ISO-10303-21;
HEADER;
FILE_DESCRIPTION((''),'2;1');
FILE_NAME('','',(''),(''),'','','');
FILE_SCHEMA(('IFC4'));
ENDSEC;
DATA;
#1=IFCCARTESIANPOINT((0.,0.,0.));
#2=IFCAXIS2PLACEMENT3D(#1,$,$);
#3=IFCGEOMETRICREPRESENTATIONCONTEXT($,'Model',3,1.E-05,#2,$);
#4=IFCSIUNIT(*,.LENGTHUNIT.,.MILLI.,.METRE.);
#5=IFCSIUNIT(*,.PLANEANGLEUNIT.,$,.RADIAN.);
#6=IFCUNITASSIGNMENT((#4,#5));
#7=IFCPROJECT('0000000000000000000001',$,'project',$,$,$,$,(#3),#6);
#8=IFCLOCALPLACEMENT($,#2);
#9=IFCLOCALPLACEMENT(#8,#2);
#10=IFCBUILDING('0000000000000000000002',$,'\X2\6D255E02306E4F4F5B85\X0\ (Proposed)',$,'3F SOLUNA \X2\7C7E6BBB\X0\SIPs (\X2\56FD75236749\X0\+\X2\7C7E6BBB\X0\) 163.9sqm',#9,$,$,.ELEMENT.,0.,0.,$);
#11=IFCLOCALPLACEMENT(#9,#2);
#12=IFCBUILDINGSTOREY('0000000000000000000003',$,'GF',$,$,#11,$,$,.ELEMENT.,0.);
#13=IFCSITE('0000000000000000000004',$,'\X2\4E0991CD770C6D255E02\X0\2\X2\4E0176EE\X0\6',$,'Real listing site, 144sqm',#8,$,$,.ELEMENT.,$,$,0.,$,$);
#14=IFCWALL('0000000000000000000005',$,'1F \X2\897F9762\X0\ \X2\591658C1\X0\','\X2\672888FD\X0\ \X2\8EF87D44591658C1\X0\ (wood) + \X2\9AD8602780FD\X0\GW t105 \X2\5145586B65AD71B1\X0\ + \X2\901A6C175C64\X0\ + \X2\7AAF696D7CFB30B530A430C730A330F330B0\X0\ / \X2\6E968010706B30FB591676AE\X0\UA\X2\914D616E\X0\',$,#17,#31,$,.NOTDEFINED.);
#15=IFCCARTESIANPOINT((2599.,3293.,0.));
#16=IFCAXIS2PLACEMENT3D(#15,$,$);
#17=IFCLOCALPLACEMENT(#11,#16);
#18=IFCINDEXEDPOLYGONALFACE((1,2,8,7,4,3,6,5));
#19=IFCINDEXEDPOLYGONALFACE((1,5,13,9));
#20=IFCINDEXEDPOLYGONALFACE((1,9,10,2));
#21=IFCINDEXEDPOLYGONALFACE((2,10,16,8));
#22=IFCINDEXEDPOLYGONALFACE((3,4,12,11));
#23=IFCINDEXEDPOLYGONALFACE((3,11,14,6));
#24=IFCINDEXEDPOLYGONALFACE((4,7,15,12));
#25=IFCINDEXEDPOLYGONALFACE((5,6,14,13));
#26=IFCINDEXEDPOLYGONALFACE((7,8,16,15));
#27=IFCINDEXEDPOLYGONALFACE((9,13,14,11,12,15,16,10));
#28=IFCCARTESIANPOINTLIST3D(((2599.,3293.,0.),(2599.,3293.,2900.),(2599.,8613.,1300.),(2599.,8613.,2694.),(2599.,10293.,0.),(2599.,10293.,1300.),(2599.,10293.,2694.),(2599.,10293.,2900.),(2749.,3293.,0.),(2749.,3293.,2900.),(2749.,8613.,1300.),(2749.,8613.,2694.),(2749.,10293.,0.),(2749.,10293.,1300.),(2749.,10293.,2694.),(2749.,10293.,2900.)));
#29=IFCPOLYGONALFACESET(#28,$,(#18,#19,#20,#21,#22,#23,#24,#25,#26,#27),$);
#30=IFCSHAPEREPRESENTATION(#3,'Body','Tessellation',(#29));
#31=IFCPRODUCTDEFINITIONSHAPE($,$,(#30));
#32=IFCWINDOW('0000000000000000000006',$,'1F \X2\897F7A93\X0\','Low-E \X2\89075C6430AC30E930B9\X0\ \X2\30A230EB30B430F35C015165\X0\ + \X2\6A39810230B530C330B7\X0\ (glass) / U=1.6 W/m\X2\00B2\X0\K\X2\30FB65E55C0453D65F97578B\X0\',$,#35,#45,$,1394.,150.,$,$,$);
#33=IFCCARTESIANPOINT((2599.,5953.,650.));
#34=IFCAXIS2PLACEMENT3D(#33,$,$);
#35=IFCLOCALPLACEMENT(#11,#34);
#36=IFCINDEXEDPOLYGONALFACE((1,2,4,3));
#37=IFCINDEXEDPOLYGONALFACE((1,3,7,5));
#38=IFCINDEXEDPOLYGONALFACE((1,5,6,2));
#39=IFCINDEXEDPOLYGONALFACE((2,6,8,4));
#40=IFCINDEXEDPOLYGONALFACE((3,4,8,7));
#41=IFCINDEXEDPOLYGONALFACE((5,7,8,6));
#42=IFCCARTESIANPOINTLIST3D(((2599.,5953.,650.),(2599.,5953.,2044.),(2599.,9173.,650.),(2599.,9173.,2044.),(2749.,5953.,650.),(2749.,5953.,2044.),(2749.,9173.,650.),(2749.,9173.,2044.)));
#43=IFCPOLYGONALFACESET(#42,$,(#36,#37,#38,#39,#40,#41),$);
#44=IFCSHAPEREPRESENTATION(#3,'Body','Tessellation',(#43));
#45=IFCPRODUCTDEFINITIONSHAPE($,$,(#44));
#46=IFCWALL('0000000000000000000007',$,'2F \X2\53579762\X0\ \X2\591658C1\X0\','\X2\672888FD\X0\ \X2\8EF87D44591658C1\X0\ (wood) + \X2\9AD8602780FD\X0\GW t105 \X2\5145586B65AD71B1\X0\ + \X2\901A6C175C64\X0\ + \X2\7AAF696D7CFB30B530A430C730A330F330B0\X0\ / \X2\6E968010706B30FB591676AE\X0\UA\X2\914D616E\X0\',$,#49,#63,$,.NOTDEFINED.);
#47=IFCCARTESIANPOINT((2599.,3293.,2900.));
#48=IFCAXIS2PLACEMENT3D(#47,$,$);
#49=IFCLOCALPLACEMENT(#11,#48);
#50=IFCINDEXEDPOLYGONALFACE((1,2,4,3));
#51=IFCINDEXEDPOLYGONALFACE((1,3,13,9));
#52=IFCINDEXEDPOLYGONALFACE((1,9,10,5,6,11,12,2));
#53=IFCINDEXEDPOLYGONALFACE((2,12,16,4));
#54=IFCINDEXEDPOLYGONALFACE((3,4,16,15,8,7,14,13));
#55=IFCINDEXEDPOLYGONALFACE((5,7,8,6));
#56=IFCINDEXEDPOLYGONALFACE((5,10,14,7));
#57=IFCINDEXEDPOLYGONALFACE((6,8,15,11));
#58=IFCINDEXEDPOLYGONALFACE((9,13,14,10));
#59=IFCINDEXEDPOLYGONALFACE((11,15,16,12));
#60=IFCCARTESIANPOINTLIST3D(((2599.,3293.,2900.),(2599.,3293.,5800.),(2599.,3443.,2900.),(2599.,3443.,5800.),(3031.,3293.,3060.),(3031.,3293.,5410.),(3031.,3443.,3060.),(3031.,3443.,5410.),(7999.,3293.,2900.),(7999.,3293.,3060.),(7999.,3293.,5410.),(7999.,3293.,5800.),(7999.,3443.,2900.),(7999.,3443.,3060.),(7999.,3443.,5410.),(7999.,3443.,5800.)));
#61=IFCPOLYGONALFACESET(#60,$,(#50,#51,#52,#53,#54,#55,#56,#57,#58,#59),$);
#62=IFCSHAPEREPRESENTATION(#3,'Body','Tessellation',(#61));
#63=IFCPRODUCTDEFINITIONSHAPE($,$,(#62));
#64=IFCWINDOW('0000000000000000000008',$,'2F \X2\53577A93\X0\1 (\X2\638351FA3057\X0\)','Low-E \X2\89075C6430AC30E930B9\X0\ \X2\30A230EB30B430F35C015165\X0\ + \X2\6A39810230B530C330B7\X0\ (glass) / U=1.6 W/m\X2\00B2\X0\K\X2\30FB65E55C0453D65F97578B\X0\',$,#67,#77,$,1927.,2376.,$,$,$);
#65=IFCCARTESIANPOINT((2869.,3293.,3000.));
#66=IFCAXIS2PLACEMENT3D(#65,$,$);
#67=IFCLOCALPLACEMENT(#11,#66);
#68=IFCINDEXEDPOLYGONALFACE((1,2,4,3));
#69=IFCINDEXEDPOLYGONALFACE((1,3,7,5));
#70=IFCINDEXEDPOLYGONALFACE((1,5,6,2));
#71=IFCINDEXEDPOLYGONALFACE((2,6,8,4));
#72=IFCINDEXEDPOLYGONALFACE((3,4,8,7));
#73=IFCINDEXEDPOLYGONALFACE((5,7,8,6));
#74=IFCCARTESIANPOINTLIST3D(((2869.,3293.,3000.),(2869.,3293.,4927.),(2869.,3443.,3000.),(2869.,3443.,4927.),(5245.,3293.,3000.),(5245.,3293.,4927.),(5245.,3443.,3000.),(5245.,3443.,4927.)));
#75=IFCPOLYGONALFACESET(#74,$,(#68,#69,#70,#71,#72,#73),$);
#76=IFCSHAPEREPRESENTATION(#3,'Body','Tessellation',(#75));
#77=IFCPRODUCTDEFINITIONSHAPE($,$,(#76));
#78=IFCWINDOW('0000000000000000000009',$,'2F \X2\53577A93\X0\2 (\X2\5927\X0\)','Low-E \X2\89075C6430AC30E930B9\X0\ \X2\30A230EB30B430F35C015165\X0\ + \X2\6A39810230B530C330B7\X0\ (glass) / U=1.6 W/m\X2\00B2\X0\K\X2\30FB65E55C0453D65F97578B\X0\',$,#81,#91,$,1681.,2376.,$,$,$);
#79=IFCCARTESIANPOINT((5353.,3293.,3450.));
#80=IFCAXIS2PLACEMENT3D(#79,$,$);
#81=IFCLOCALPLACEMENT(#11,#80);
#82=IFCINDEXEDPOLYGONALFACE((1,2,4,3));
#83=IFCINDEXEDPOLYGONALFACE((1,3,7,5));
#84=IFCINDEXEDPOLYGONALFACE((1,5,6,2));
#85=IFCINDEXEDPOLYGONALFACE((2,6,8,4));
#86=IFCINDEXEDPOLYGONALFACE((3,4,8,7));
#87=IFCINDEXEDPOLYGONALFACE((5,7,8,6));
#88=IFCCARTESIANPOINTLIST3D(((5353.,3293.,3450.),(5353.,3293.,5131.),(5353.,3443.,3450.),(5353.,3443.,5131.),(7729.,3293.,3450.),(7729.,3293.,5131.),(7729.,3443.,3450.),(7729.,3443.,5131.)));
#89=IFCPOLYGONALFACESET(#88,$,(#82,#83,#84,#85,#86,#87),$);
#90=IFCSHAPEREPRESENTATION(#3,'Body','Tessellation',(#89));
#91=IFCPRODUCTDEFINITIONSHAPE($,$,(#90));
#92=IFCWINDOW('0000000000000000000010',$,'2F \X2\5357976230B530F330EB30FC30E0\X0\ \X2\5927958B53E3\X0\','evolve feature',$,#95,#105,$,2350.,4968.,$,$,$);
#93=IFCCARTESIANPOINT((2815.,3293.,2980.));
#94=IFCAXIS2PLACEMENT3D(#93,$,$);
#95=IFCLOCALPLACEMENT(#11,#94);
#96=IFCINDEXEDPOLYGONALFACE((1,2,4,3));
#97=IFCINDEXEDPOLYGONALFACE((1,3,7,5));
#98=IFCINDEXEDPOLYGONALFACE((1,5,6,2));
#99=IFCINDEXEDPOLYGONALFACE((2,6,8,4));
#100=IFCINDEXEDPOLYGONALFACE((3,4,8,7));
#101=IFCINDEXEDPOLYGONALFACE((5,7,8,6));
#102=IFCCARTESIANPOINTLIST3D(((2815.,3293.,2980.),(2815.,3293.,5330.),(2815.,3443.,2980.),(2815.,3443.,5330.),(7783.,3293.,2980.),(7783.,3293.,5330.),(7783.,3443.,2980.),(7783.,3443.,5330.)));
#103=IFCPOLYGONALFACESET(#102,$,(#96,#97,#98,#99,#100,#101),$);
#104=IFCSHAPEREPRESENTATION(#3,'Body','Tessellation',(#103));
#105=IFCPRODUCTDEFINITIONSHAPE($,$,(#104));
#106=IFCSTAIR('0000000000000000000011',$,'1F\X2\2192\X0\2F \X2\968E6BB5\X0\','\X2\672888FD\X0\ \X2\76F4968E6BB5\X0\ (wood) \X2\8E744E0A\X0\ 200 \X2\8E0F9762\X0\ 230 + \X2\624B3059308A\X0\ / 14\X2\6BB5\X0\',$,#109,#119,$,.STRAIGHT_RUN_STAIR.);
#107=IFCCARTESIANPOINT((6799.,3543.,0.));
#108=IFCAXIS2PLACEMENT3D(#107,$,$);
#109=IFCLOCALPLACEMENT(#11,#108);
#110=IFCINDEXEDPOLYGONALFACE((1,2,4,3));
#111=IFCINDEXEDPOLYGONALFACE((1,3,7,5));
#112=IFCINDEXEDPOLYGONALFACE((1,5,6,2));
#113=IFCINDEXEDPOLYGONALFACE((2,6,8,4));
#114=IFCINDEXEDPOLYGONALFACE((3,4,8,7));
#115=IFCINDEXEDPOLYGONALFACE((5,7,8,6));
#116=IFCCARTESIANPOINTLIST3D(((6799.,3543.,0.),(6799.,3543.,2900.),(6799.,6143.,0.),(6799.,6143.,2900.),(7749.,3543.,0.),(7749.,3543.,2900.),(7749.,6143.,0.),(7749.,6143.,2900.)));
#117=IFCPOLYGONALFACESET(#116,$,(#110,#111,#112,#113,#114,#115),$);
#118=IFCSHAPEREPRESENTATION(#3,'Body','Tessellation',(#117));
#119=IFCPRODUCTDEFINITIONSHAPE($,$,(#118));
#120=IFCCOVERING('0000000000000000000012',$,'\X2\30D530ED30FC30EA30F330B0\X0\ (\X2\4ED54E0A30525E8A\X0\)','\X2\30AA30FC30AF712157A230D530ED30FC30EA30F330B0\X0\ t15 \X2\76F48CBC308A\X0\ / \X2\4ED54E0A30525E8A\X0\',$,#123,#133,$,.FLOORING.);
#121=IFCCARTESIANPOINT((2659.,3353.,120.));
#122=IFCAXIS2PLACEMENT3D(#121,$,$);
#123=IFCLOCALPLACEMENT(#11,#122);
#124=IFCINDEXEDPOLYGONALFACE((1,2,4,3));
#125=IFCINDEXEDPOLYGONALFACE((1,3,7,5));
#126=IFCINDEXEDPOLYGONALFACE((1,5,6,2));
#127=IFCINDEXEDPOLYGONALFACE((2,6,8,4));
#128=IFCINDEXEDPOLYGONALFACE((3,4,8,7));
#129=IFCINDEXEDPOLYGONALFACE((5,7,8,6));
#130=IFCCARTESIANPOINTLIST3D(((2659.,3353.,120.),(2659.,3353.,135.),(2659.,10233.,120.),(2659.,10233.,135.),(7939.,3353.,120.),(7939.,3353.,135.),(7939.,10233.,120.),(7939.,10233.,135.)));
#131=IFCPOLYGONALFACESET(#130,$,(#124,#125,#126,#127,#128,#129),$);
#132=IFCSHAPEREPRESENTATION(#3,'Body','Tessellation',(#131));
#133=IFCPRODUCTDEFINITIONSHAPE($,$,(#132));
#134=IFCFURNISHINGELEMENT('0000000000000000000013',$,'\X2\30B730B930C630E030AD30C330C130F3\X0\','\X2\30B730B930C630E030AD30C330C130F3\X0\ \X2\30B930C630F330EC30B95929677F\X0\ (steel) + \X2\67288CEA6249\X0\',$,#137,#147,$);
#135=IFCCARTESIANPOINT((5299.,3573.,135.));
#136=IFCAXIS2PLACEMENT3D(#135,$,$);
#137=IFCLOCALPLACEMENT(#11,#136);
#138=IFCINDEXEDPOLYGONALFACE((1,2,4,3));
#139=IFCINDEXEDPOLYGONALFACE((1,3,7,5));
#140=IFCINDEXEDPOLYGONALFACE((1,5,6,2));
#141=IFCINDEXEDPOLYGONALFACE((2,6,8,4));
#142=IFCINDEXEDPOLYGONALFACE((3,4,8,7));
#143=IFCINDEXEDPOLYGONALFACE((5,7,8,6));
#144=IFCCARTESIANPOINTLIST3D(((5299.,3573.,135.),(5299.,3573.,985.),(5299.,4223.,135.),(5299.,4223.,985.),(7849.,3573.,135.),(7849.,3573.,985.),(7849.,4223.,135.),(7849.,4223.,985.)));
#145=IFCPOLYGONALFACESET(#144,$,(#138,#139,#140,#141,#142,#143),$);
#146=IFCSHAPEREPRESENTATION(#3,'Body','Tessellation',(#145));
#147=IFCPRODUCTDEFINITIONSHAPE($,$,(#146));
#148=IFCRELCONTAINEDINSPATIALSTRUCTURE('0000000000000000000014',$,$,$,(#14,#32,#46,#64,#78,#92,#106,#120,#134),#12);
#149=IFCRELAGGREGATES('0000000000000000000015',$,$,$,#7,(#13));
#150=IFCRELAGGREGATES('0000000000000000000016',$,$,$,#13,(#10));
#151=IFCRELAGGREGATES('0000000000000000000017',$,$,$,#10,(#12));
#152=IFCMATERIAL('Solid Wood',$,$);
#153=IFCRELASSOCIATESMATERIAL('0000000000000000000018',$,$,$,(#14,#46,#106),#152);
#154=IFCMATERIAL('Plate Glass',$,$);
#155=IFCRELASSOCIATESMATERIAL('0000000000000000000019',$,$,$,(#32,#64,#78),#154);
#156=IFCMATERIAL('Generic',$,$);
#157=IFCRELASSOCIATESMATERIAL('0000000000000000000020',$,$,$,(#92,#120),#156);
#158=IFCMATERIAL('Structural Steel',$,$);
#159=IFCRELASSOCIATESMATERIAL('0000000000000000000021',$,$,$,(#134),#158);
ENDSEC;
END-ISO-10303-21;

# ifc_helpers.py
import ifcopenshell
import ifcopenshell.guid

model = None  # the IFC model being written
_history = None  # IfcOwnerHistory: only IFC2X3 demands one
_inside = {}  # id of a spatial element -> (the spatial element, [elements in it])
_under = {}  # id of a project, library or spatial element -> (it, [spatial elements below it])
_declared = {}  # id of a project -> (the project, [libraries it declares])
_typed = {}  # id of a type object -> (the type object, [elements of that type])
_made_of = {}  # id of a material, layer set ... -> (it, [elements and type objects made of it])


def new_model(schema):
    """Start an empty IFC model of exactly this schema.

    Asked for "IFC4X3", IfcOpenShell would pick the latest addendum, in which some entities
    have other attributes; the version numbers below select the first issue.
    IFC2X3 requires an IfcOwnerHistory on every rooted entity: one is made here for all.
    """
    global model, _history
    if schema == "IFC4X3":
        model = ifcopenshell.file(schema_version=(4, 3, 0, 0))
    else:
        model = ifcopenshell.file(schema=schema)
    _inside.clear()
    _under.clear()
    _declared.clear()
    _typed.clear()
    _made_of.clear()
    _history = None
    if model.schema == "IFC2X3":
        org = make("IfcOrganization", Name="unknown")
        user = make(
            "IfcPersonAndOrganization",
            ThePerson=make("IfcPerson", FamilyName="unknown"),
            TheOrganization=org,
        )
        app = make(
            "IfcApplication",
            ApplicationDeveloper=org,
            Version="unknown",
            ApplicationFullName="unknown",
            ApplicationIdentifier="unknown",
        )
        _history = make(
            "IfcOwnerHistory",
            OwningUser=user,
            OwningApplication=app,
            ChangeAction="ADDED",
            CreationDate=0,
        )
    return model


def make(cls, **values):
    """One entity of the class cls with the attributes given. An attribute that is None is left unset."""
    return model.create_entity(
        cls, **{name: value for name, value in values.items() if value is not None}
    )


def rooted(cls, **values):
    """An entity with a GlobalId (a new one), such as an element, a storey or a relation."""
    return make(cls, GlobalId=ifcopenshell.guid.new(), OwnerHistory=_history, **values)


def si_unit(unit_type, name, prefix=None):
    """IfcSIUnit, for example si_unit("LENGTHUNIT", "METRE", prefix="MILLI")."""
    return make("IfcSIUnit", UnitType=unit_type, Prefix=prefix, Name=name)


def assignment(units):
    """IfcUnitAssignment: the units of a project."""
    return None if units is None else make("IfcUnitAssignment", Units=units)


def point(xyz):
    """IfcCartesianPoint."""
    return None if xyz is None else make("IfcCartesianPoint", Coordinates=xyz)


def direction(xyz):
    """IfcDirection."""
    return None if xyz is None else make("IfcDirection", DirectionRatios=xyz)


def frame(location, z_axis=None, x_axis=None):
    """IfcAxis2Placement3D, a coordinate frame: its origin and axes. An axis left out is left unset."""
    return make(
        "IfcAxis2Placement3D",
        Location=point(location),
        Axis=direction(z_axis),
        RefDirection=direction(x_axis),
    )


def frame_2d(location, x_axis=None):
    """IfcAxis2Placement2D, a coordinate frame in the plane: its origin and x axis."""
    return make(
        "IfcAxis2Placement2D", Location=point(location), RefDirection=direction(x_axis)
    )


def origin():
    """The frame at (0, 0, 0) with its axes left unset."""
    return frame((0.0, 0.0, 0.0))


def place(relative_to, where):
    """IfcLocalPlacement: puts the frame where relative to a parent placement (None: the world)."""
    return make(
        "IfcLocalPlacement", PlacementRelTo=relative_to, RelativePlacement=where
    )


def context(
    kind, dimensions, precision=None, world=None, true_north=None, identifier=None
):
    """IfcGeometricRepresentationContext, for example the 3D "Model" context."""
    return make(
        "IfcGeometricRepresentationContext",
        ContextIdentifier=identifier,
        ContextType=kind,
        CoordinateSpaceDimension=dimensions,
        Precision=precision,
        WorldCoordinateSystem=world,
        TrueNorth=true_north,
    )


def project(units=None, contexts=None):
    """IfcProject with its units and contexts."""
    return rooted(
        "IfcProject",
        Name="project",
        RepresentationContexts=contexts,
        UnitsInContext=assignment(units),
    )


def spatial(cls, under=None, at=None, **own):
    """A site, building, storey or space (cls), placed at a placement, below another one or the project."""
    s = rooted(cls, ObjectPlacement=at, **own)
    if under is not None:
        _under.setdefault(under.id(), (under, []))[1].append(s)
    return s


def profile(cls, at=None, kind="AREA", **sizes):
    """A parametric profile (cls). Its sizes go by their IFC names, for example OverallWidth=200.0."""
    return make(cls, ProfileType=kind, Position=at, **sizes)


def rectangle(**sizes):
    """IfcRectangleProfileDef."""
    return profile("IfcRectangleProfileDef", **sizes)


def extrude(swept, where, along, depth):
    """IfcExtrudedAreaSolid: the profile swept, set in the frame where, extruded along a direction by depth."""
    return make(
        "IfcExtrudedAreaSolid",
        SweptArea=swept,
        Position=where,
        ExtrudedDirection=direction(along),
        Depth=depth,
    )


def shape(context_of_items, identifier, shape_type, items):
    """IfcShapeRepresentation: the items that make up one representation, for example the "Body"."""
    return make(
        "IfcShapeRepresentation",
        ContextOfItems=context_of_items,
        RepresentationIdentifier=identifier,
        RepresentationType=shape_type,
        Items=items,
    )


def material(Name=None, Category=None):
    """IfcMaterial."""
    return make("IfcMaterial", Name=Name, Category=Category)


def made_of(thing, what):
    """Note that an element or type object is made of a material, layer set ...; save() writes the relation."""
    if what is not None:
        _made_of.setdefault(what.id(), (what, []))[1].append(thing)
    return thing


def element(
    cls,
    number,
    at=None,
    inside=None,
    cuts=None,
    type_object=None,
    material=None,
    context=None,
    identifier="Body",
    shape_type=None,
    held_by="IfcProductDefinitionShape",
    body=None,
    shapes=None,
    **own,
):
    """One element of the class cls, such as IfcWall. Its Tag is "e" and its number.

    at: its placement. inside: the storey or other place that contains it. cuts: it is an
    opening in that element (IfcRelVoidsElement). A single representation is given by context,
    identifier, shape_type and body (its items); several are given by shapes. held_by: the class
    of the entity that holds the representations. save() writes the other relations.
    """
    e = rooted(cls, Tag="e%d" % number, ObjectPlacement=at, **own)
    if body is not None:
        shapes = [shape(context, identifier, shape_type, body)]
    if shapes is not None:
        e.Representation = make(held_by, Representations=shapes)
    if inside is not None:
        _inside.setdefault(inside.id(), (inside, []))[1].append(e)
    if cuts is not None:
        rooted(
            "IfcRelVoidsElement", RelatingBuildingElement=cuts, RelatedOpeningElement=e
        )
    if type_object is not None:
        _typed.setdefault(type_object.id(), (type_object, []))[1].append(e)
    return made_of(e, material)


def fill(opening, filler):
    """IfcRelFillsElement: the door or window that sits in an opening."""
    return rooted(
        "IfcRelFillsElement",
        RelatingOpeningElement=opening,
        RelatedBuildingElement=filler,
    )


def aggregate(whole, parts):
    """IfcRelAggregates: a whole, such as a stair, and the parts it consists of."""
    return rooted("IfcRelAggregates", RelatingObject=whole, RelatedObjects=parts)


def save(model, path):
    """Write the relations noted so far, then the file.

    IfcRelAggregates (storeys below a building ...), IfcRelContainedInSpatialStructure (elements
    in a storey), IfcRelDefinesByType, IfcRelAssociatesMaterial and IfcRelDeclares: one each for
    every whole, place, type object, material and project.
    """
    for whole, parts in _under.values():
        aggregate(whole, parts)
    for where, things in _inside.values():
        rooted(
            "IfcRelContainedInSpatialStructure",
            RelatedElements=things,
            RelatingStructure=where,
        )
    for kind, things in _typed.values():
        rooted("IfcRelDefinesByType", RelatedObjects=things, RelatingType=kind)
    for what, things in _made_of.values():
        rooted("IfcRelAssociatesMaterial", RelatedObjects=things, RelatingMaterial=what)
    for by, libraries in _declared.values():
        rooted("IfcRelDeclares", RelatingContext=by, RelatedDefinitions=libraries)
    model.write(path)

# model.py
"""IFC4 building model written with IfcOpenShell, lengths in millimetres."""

from ifc_helpers import new_model, si_unit, frame, frame_2d, origin, place, context, project, spatial, rectangle, extrude, material, element, fill, save


model = new_model("IFC4")

# Units and contexts
model_context = context("Model", 3, precision=1e-05, world=origin())
ifc_project = project(units=[si_unit("LENGTHUNIT", "METRE", prefix="MILLI"), si_unit("PLANEANGLEUNIT", "RADIAN")], contexts=[model_context])

# Site, building, storey
site_placement = place(None, origin())
site = spatial("IfcSite", under=ifc_project, at=site_placement, Name="三重県津市2丁目6", ObjectType="Real listing site, 144sqm", CompositionType="ELEMENT", RefElevation=0.0)
building_placement = place(site_placement, origin())
building = spatial("IfcBuilding", under=site, at=building_placement, Name="津市の住宅 (Proposed)", ObjectType="3F SOLUNA 籾殻SIPs (国産杉+籾殻) 163.9sqm", CompositionType="ELEMENT", ElevationOfRefHeight=0.0, ElevationOfTerrain=0.0)
storey_placement = place(building_placement, origin())
storey = spatial("IfcBuildingStorey", under=building, at=storey_placement, Name="GF", CompositionType="ELEMENT", Elevation=0.0)

# Shared definitions
ifc_material_1 = material(Name="Solid Wood")
ifc_material_2 = material(Name="Generic")

# Shared definitions
ifc_material_3 = material(Name="Plate Glass")

# Wall, opening, window
wall_1_placement = place(storey_placement, frame((2599.0, 3293.0, 0.0)))
wall_1 = element("IfcWall", 1, at=wall_1_placement, inside=storey, material=ifc_material_1, Name="1F 西面 外壁", Description="木製 軸組外壁 (wood) + 高性能GW t105 充填断熱 + 通気層 + 窯業系サイディング / 準耐火・外皮UA配慮", PredefinedType="NOTDEFINED", context=model_context, shape_type="SweptSolid", body=[
    extrude(rectangle(XDim=150.0, YDim=7000.0, at=frame_2d((75.0, 3500.0))), frame((2599.0, 3293.0, 0.0)), (0.0, 0.0, 1.0), 2900.0),
])
opening_1_placement = place(storey_placement, frame((2599.0, 5953.0, 650.0)))
opening_1 = element("IfcOpeningElement", 2, at=opening_1_placement, cuts=wall_1, PredefinedType="NOTDEFINED", context=model_context, shape_type="SweptSolid", body=[
    extrude(rectangle(XDim=150.0, YDim=3220.0, at=frame_2d((75.0, 1610.0))), frame((2599.0, 5953.0, 650.0)), (0.0, 0.0, 1.0), 1394.0),
])
window_1_placement = place(storey_placement, frame((2599.0, 5953.0, 650.0)))
window_1 = element("IfcWindow", 3, at=window_1_placement, inside=storey, material=ifc_material_3, Name="1F 西窓", Description="Low-E 複層ガラス アルゴン封入 + 樹脂サッシ (glass) / U=1.6 W/m²K・日射取得型", OverallHeight=1394.0, OverallWidth=150.0, context=model_context, shape_type="SweptSolid", body=[
    extrude(rectangle(XDim=150.0, YDim=3220.0, at=frame_2d((75.0, 1610.0))), frame((2599.0, 5953.0, 650.0)), (0.0, 0.0, 1.0), 1394.0),
])
fill(opening_1, window_1)

# Wall, openings, windows
wall_2_placement = place(storey_placement, frame((2599.0, 3293.0, 2900.0)))
wall_2 = element("IfcWall", 4, at=wall_2_placement, inside=storey, material=ifc_material_1, Name="2F 南面 外壁", Description="木製 軸組外壁 (wood) + 高性能GW t105 充填断熱 + 通気層 + 窯業系サイディング / 準耐火・外皮UA配慮", PredefinedType="NOTDEFINED", context=model_context, shape_type="SweptSolid", body=[
    extrude(rectangle(XDim=5400.0, YDim=150.0, at=frame_2d((2700.0, 75.0))), frame((2599.0, 3293.0, 2900.0)), (0.0, 0.0, 1.0), 2900.0),
])
opening_2_placement = place(storey_placement, frame((2869.0, 3293.0, 3000.0)))
opening_2 = element("IfcOpeningElement", 5, at=opening_2_placement, cuts=wall_2, PredefinedType="NOTDEFINED", context=model_context, shape_type="SweptSolid", body=[
    extrude(rectangle(XDim=2376.0, YDim=150.0, at=frame_2d((1188.0, 75.0))), frame((2869.0, 3293.0, 3000.0)), (0.0, 0.0, 1.0), 1927.0),
])
opening_3_placement = place(storey_placement, frame((5353.0, 3293.0, 3450.0)))
opening_3 = element("IfcOpeningElement", 6, at=opening_3_placement, cuts=wall_2, PredefinedType="NOTDEFINED", context=model_context, shape_type="SweptSolid", body=[
    extrude(rectangle(XDim=2376.0, YDim=150.0, at=frame_2d((1188.0, 75.0))), frame((5353.0, 3293.0, 3450.0)), (0.0, 0.0, 1.0), 1681.0),
])
opening_4_placement = place(storey_placement, frame((2815.0, 3293.0, 2980.0)))
opening_4 = element("IfcOpeningElement", 7, at=opening_4_placement, cuts=wall_2, PredefinedType="NOTDEFINED", context=model_context, shape_type="SweptSolid", body=[
    extrude(rectangle(XDim=4968.0, YDim=150.0, at=frame_2d((2484.0, 75.0))), frame((2815.0, 3293.0, 2980.0)), (0.0, 0.0, 1.0), 2350.0),
])
window_2_placement = place(storey_placement, frame((2869.0, 3293.0, 3000.0)))
window_2 = element("IfcWindow", 8, at=window_2_placement, inside=storey, material=ifc_material_3, Name="2F 南窓1 (掃出し)", Description="Low-E 複層ガラス アルゴン封入 + 樹脂サッシ (glass) / U=1.6 W/m²K・日射取得型", OverallHeight=1927.0, OverallWidth=2376.0, context=model_context, shape_type="SweptSolid", body=[
    extrude(rectangle(XDim=2376.0, YDim=150.0, at=frame_2d((1188.0, 75.0))), frame((2869.0, 3293.0, 3000.0)), (0.0, 0.0, 1.0), 1927.0),
])
fill(opening_2, window_2)
window_3_placement = place(storey_placement, frame((5353.0, 3293.0, 3450.0)))
window_3 = element("IfcWindow", 9, at=window_3_placement, inside=storey, material=ifc_material_3, Name="2F 南窓2 (大)", Description="Low-E 複層ガラス アルゴン封入 + 樹脂サッシ (glass) / U=1.6 W/m²K・日射取得型", OverallHeight=1681.0, OverallWidth=2376.0, context=model_context, shape_type="SweptSolid", body=[
    extrude(rectangle(XDim=2376.0, YDim=150.0, at=frame_2d((1188.0, 75.0))), frame((5353.0, 3293.0, 3450.0)), (0.0, 0.0, 1.0), 1681.0),
])
fill(opening_3, window_3)
window_4_placement = place(storey_placement, frame((2815.0, 3293.0, 2980.0)))
window_4 = element("IfcWindow", 10, at=window_4_placement, inside=storey, material=ifc_material_2, Name="2F 南面サンルーム 大開口", Description="evolve feature", OverallHeight=2350.0, OverallWidth=4968.0, context=model_context, shape_type="SweptSolid", body=[
    extrude(rectangle(XDim=4968.0, YDim=150.0, at=frame_2d((2484.0, 75.0))), frame((2815.0, 3293.0, 2980.0)), (0.0, 0.0, 1.0), 2350.0),
])
fill(opening_4, window_4)

# Stair
stair_placement = place(storey_placement, frame((6799.0, 3543.0, 0.0)))
element("IfcStair", 11, at=stair_placement, inside=storey, material=ifc_material_1, Name="1F→2F 階段", Description="木製 直階段 (wood) 蹴上 200 踏面 230 + 手すり / 14段", PredefinedType="STRAIGHT_RUN_STAIR", context=model_context, shape_type="SweptSolid", body=[
    extrude(rectangle(XDim=950.0, YDim=2600.0, at=frame_2d((475.0, 1300.0))), frame((6799.0, 3543.0, 0.0)), (0.0, 0.0, 1.0), 2900.0),
])

# Covering
covering_placement = place(storey_placement, frame((2659.0, 3353.0, 120.0)))
element("IfcCovering", 12, at=covering_placement, inside=storey, material=ifc_material_2, Name="フローリング (仕上げ床)", Description="オーク無垢フローリング t15 直貼り / 仕上げ床", PredefinedType="FLOORING", context=model_context, shape_type="SweptSolid", body=[
    extrude(rectangle(XDim=5280.0, YDim=6880.0, at=frame_2d((2640.0, 3440.0))), frame((2659.0, 3353.0, 120.0)), (0.0, 0.0, 1.0), 15.0),
])

# Furnishing element
ifc_material_4 = material(Name="Structural Steel")
furnishing_placement = place(storey_placement, frame((5299.0, 3573.0, 135.0)))
element("IfcFurnishingElement", 13, at=furnishing_placement, inside=storey, material=ifc_material_4, Name="システムキッチン", Description="システムキッチン ステンレス天板 (steel) + 木質扉", context=model_context, shape_type="SweptSolid", body=[
    extrude(rectangle(XDim=2550.0, YDim=650.0, at=frame_2d((1275.0, 325.0))), frame((5299.0, 3573.0, 135.0)), (0.0, 0.0, 1.0), 850.0),
])

save(model, "model.ifc")
